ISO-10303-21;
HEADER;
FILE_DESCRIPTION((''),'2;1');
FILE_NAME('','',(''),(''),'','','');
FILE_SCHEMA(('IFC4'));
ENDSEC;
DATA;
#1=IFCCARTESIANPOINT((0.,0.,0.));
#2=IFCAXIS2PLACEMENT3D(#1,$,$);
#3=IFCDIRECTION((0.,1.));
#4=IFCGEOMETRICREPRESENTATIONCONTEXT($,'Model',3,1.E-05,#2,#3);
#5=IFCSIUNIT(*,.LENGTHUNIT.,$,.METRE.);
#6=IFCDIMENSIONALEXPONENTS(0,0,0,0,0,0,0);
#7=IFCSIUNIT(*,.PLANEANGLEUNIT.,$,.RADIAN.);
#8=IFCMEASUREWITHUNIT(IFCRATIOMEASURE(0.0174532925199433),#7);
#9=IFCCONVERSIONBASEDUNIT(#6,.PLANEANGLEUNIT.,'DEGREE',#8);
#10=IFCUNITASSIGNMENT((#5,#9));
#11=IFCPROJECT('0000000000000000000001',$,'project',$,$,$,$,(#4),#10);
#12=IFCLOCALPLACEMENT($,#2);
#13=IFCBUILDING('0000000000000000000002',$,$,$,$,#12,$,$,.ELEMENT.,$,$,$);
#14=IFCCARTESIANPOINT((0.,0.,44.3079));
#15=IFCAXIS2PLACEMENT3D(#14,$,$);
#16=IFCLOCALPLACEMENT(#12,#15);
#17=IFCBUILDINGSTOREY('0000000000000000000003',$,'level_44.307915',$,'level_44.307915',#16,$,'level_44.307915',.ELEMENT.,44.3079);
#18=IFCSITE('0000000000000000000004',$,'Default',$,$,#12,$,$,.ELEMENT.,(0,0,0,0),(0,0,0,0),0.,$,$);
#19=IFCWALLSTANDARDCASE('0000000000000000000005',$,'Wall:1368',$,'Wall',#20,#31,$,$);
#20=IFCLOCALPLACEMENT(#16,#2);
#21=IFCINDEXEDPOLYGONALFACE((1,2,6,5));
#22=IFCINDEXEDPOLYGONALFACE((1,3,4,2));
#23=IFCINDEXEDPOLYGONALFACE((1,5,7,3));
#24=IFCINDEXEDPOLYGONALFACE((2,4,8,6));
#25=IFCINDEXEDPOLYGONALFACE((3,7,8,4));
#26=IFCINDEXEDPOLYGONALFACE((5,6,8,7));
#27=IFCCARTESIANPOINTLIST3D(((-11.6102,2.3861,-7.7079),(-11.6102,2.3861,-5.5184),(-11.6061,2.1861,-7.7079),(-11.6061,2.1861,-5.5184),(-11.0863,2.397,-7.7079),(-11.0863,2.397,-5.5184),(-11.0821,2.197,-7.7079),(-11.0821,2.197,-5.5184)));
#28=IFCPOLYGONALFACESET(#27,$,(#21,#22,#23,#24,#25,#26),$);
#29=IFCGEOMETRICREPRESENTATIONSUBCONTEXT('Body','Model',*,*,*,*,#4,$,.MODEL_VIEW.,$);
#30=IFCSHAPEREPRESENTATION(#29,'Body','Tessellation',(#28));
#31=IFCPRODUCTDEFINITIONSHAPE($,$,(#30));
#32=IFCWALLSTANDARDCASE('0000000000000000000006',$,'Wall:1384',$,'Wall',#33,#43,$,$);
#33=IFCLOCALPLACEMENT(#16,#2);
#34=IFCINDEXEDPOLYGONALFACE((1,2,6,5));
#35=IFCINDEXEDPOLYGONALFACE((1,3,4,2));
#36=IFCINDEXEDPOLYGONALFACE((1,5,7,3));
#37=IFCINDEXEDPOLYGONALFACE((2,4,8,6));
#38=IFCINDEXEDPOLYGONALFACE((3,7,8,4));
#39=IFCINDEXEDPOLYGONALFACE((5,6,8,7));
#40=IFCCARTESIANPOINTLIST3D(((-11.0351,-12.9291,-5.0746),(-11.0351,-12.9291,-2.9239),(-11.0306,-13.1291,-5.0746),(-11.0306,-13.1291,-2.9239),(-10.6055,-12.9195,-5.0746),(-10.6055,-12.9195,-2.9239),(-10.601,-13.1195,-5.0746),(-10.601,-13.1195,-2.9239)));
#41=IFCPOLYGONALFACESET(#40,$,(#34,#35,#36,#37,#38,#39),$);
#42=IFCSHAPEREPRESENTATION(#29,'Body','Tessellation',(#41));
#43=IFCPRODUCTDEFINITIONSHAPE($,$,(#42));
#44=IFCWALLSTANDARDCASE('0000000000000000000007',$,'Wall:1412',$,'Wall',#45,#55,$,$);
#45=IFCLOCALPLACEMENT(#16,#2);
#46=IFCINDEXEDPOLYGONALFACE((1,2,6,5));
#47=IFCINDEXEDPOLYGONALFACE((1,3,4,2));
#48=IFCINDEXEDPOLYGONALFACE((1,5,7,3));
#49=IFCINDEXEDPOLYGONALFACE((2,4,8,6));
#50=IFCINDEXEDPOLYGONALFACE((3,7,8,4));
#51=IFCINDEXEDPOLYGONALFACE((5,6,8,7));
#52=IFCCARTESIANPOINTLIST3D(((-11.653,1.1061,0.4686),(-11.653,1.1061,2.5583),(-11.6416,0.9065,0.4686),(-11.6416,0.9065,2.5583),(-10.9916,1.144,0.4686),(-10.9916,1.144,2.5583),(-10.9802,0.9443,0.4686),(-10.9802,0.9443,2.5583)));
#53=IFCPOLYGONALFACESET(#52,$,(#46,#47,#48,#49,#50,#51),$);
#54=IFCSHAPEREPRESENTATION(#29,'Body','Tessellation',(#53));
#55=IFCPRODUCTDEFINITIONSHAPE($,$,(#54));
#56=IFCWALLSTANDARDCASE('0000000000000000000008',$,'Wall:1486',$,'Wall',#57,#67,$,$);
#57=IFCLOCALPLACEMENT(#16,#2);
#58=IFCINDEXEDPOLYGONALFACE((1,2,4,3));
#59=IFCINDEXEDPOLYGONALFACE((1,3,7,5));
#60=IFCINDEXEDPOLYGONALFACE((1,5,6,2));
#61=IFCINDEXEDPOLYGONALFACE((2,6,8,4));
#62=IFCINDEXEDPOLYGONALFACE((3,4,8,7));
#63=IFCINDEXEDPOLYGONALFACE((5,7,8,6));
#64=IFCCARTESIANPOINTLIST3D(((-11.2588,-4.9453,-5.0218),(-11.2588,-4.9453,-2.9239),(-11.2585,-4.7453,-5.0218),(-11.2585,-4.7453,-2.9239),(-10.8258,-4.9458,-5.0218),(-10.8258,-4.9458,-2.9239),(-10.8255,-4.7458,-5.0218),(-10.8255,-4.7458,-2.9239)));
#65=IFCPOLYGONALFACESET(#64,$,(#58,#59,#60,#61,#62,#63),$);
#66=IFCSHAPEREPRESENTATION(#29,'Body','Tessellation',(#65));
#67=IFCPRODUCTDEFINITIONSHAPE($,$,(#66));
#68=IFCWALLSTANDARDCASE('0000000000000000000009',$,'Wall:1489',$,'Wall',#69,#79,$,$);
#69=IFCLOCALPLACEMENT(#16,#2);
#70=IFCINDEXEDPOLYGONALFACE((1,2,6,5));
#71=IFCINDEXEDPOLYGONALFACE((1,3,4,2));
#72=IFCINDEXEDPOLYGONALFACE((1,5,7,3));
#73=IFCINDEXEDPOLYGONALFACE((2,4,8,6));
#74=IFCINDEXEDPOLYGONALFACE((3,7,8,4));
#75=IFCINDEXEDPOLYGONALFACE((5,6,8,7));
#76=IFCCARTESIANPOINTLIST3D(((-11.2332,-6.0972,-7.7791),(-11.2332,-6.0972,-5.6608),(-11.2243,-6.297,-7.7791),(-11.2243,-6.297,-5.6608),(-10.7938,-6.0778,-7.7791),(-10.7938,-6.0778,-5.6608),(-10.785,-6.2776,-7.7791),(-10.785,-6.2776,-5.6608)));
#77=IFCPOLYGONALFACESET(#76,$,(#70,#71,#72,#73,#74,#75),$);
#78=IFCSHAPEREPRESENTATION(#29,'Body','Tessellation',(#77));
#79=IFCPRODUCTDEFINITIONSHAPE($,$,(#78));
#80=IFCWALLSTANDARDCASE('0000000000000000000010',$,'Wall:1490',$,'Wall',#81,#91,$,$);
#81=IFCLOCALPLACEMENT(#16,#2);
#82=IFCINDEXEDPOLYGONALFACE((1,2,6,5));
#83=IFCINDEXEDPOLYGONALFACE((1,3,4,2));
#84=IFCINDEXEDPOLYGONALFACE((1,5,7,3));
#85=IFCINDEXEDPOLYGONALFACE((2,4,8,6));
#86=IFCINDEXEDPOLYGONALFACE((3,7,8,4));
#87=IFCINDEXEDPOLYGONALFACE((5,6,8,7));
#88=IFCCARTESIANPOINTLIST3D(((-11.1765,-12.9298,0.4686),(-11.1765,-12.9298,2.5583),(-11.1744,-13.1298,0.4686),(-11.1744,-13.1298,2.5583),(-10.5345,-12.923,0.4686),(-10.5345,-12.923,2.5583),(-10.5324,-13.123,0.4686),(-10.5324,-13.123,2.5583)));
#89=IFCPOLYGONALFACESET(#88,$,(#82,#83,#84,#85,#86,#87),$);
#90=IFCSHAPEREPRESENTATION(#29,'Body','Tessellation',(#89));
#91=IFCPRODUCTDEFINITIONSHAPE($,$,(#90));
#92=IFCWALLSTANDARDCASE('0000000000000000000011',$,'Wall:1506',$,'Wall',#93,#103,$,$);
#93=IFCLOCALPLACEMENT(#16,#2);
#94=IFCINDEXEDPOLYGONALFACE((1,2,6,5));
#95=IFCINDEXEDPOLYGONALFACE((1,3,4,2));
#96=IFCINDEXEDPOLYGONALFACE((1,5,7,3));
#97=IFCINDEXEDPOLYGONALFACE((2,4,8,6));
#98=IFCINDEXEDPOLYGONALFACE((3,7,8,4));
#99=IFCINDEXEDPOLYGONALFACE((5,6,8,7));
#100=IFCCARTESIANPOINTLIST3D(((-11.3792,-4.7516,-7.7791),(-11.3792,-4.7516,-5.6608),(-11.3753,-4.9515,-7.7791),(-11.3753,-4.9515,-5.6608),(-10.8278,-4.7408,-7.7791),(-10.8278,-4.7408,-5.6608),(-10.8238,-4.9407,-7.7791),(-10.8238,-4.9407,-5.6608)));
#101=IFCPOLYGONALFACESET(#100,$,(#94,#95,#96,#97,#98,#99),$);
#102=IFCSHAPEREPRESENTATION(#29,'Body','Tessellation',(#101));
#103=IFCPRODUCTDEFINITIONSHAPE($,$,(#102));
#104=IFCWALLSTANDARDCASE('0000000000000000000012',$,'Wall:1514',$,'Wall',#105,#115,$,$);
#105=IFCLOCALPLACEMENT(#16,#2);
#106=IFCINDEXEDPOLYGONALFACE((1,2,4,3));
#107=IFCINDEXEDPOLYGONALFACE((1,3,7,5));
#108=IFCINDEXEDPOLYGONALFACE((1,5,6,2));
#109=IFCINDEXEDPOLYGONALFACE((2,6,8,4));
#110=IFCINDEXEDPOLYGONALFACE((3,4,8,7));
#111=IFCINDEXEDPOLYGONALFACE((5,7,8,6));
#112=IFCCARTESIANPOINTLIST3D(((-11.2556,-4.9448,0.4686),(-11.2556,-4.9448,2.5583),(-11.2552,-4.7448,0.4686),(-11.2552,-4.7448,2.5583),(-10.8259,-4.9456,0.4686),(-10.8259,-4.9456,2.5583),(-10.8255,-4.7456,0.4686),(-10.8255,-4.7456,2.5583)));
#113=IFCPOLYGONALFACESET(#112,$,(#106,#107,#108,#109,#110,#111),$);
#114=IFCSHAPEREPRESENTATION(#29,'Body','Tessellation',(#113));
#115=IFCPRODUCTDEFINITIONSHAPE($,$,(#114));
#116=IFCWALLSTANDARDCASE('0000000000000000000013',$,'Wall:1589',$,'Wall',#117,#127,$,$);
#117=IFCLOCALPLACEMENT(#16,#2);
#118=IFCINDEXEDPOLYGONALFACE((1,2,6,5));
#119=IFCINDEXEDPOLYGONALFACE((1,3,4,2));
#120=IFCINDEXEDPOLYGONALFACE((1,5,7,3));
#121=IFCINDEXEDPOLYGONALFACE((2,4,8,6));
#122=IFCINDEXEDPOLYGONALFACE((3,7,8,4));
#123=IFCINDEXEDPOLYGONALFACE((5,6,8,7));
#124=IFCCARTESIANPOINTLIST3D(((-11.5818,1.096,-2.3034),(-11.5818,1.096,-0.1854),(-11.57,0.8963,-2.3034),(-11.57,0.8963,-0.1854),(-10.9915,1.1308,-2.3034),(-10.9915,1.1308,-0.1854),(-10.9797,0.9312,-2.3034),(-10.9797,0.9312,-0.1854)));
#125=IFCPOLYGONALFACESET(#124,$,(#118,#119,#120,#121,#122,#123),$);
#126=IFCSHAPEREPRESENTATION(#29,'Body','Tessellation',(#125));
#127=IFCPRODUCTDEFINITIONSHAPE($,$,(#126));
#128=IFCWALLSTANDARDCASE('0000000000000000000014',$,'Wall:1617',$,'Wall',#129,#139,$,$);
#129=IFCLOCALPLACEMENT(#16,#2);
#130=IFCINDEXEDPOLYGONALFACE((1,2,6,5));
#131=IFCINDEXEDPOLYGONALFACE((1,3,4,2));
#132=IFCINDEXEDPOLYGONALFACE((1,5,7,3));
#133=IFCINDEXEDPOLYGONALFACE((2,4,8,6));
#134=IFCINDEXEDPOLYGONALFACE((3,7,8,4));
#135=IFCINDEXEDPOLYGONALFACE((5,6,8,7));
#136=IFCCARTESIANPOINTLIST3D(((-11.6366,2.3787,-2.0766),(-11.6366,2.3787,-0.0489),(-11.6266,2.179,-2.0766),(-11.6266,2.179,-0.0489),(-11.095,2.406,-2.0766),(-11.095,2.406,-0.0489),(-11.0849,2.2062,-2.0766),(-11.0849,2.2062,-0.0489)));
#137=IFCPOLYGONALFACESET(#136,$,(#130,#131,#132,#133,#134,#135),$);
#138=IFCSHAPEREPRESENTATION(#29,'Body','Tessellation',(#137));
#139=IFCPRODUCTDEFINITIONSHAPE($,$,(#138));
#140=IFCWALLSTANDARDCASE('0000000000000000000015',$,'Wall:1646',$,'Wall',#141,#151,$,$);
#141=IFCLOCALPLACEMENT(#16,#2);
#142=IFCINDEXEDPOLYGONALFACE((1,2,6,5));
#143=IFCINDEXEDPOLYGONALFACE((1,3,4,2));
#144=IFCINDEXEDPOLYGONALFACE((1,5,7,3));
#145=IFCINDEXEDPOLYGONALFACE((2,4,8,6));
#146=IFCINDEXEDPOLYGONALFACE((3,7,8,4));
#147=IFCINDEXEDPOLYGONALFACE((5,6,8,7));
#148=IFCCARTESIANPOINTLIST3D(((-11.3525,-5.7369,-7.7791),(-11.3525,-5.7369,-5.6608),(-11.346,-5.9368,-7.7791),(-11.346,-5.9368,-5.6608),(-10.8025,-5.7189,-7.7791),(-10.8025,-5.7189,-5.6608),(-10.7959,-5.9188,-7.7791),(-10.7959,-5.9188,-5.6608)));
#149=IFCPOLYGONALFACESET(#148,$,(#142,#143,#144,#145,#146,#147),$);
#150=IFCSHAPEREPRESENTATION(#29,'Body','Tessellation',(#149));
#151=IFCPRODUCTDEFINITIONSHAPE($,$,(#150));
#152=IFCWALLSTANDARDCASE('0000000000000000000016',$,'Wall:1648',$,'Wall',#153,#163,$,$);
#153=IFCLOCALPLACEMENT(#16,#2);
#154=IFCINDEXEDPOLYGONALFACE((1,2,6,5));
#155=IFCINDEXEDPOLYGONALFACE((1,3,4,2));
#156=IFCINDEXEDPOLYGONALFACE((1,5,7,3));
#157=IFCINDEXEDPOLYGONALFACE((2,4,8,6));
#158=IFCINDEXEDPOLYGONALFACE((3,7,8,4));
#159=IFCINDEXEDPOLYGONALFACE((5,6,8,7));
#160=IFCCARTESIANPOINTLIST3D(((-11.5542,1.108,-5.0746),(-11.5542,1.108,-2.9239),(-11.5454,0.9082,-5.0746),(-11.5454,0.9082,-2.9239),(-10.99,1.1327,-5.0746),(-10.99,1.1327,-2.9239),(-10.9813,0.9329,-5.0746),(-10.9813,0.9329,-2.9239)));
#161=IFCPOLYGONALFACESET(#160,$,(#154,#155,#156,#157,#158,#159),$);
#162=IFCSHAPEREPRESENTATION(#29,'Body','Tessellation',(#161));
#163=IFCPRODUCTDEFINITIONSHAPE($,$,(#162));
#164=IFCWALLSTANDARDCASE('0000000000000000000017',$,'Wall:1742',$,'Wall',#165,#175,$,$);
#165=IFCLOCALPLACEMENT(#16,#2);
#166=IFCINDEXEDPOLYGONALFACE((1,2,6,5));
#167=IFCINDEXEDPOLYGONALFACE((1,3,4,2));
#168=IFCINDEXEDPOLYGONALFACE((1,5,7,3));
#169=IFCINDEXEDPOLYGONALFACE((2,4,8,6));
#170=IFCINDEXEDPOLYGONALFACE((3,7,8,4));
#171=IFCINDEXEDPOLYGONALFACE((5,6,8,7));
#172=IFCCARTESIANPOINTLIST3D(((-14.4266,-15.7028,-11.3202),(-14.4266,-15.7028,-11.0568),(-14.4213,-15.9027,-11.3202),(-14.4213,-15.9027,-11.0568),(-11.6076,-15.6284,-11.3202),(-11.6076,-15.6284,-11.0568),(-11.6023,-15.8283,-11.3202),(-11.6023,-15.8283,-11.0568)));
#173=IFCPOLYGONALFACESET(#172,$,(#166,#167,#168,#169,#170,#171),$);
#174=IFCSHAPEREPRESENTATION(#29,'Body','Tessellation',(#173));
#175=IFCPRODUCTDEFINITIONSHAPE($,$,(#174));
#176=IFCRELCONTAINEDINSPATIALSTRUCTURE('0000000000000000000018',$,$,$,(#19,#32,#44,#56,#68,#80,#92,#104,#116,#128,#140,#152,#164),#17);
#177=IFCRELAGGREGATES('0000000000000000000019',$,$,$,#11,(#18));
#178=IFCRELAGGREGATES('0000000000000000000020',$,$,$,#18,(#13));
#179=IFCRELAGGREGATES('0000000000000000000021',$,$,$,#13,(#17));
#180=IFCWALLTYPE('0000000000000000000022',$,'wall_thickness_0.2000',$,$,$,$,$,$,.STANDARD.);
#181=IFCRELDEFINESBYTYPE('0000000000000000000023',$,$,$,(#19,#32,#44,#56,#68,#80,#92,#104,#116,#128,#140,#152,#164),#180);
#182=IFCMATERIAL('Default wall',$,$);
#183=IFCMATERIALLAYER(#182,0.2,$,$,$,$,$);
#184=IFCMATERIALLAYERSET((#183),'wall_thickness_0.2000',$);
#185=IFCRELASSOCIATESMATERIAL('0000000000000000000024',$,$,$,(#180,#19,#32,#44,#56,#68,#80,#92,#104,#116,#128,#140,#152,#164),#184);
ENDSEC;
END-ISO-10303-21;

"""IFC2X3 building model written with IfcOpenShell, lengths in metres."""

from ifc_helpers import new_model, entity, si_unit, converted_unit, direction, frame, origin, place, context, subcontext, project, spatial, polyline, outline, extrude, material, layer, layer_set, layer_usage, type_object, element, save


model = new_model("IFC2X3")

# Units and contexts
model_context = context("Model", 3, precision=1e-05, world=origin(), true_north=direction((0.0, 1.0)))
body_context = subcontext(model_context, "Body", "Model", "MODEL_VIEW")
ifc_project = project(units=[si_unit("LENGTHUNIT", "METRE"), converted_unit("PLANEANGLEUNIT", "DEGREE", entity("IfcRatioMeasure", 0.0174532925199433), si_unit("PLANEANGLEUNIT", "RADIAN"), dimensions=[0, 0, 0, 0, 0, 0, 0])], contexts=[model_context])

# Site, building, storey
placement_1 = place(None, origin())
site = spatial("IfcSite", under=ifc_project, at=placement_1, Name="Default", CompositionType="ELEMENT", RefLatitude=(0, 0, 0, 0), RefLongitude=(0, 0, 0, 0), RefElevation=0.0)
building = spatial("IfcBuilding", under=site, at=placement_1, CompositionType="ELEMENT")
storey_placement = place(placement_1, frame((0.0, 0.0, 44.3079)))
storey = spatial("IfcBuildingStorey", under=building, at=storey_placement, Name="level_44.307915", ObjectType="level_44.307915", LongName="level_44.307915", CompositionType="ELEMENT", Elevation=44.3079)

# Walls
ifc_material_1 = material(Name="Default wall")
ifc_layer = layer(ifc_material_1, 0.2)
ifc_layer_set = layer_set([ifc_layer], Name="wall_thickness_0.2000")
ifc_layer_usage = layer_usage(ifc_layer_set, "AXIS2", "POSITIVE", -0.1)
wall_type = type_object("IfcWallType", Name="wall_thickness_0.2000", PredefinedType="STANDARD", material=ifc_layer_set)
placement_2 = place(placement_1, frame((0.0, 0.0, 36.6)))
wall_1_placement = place(placement_2, frame((-11.0842, 2.297, 0.0), z_axis=(0.0, 0.0, 1.0), x_axis=(-0.999783, -0.020848, 0.0)))
element("IfcWallStandardCase", 1, at=wall_1_placement, inside=storey, type_object=wall_type, material=ifc_layer_usage, Name="Wall:1368", ObjectType="Wall", context=body_context, shape_type="SweptSolid", body=[
    extrude(outline(polyline([(0.5241, -0.1), (0.5241, 0.1), (0.0, 0.1), (0.0, -0.1), (0.5241, -0.1)])), origin(), (0.0, 0.0, 1.0), 2.1895),
])
placement_3 = place(placement_1, frame((0.0, 0.0, 39.2333)))
wall_2_placement = place(placement_3, frame((-10.6033, -13.0195, 0.0), z_axis=(0.0, 0.0, 1.0), x_axis=(-0.99975, -0.022373, 0.0)))
element("IfcWallStandardCase", 2, at=wall_2_placement, inside=storey, type_object=wall_type, material=ifc_layer_usage, Name="Wall:1384", ObjectType="Wall", context=body_context, shape_type="SweptSolid", body=[
    extrude(outline(polyline([(0.4297, -0.1), (0.4297, 0.1), (0.0, 0.1), (0.0, -0.1), (0.4297, -0.1)])), origin(), (0.0, 0.0, 1.0), 2.1507),
])
placement_4 = place(placement_1, frame((0.0, 0.0, 44.7765)))
wall_3_placement = place(placement_4, frame((-10.9859, 1.0441, 0.0), z_axis=(0.0, 0.0, 1.0), x_axis=(-0.99837, -0.05708, 0.0)))
element("IfcWallStandardCase", 3, at=wall_3_placement, inside=storey, type_object=wall_type, material=ifc_layer_usage, Name="Wall:1412", ObjectType="Wall", context=body_context, shape_type="SweptSolid", body=[
    extrude(outline(polyline([(0.6624, -0.1), (0.6624, 0.1), (0.0, 0.1), (0.0, -0.1), (0.6624, -0.1)])), origin(), (0.0, 0.0, 1.0), 2.0897),
])
placement_5 = place(placement_1, frame((0.0, 0.0, 39.2861)))
wall_4_placement = place(placement_5, frame((-10.8257, -4.8458, 0.0), z_axis=(0.0, 0.0, 1.0), x_axis=(-0.999999, 0.001249, 0.0)))
element("IfcWallStandardCase", 4, at=wall_4_placement, inside=storey, type_object=wall_type, material=ifc_layer_usage, Name="Wall:1486", ObjectType="Wall", context=body_context, shape_type="SweptSolid", body=[
    extrude(outline(polyline([(0.433, -0.1), (0.433, 0.1), (0.0, 0.1), (0.0, -0.1), (0.433, -0.1)])), origin(), (0.0, 0.0, 1.0), 2.0979),
])
placement_6 = place(placement_1, frame((0.0, 0.0, 36.5288)))
wall_5_placement = place(placement_6, frame((-10.7894, -6.1777, 0.0), z_axis=(0.0, 0.0, 1.0), x_axis=(-0.999024, -0.044163, 0.0)))
element("IfcWallStandardCase", 5, at=wall_5_placement, inside=storey, type_object=wall_type, material=ifc_layer_usage, Name="Wall:1489", ObjectType="Wall", context=body_context, shape_type="SweptSolid", body=[
    extrude(outline(polyline([(0.4398, -0.1), (0.4398, 0.1), (0.0, 0.1), (0.0, -0.1), (0.4398, -0.1)])), origin(), (0.0, 0.0, 1.0), 2.1183),
])
placement_7 = place(placement_1, frame((0.0, 0.0, 44.7765)))
wall_6_placement = place(placement_7, frame((-10.5334, -13.023, 0.0), z_axis=(0.0, 0.0, 1.0), x_axis=(-0.999945, -0.010496, 0.0)))
element("IfcWallStandardCase", 6, at=wall_6_placement, inside=storey, type_object=wall_type, material=ifc_layer_usage, Name="Wall:1490", ObjectType="Wall", context=body_context, shape_type="SweptSolid", body=[
    extrude(outline(polyline([(0.6421, -0.1), (0.6421, 0.1), (0.0, 0.1), (0.0, -0.1), (0.6421, -0.1)])), origin(), (0.0, 0.0, 1.0), 2.0897),
])
placement_8 = place(placement_1, frame((0.0, 0.0, 36.5288)))
wall_7_placement = place(placement_8, frame((-10.8258, -4.8407, 0.0), z_axis=(0.0, 0.0, 1.0), x_axis=(-0.999808, -0.019607, 0.0)))
element("IfcWallStandardCase", 7, at=wall_7_placement, inside=storey, type_object=wall_type, material=ifc_layer_usage, Name="Wall:1506", ObjectType="Wall", context=body_context, shape_type="SweptSolid", body=[
    extrude(outline(polyline([(0.5516, -0.1), (0.5516, 0.1), (0.0, 0.1), (0.0, -0.1), (0.5516, -0.1)])), origin(), (0.0, 0.0, 1.0), 2.1183),
])
placement_9 = place(placement_1, frame((0.0, 0.0, 44.7765)))
wall_8_placement = place(placement_9, frame((-10.8257, -4.8456, 0.0), z_axis=(0.0, 0.0, 1.0), x_axis=(-0.999998, 0.001954, 0.0)))
element("IfcWallStandardCase", 8, at=wall_8_placement, inside=storey, type_object=wall_type, material=ifc_layer_usage, Name="Wall:1514", ObjectType="Wall", context=body_context, shape_type="SweptSolid", body=[
    extrude(outline(polyline([(0.4297, -0.1), (0.4297, 0.1), (0.0, 0.1), (0.0, -0.1), (0.4297, -0.1)])), origin(), (0.0, 0.0, 1.0), 2.0897),
])
placement_10 = place(placement_1, frame((0.0, 0.0, 42.0045)))
wall_9_placement = place(placement_10, frame((-10.9856, 1.031, 0.0), z_axis=(0.0, 0.0, 1.0), x_axis=(-0.998263, -0.05892, 0.0)))
element("IfcWallStandardCase", 9, at=wall_9_placement, inside=storey, type_object=wall_type, material=ifc_layer_usage, Name="Wall:1589", ObjectType="Wall", context=body_context, shape_type="SweptSolid", body=[
    extrude(outline(polyline([(0.5913, -0.1), (0.5913, 0.1), (0.0, 0.1), (0.0, -0.1), (0.5913, -0.1)])), origin(), (0.0, 0.0, 1.0), 2.118),
])
placement_11 = place(placement_1, frame((0.0, 0.0, 42.2313)))
wall_10_placement = place(placement_11, frame((-11.0899, 2.3061, 0.0), z_axis=(0.0, 0.0, 1.0), x_axis=(-0.998738, -0.050226, 0.0)))
element("IfcWallStandardCase", 10, at=wall_10_placement, inside=storey, type_object=wall_type, material=ifc_layer_usage, Name="Wall:1617", ObjectType="Wall", context=body_context, shape_type="SweptSolid", body=[
    extrude(outline(polyline([(0.5423, -0.1), (0.5423, 0.1), (0.0, 0.1), (0.0, -0.1), (0.5423, -0.1)])), origin(), (0.0, 0.0, 1.0), 2.0278),
])
placement_12 = place(placement_1, frame((0.0, 0.0, 36.5288)))
wall_11_placement = place(placement_12, frame((-10.7992, -5.8188, 0.0), z_axis=(0.0, 0.0, 1.0), x_axis=(-0.999462, -0.032802, 0.0)))
element("IfcWallStandardCase", 11, at=wall_11_placement, inside=storey, type_object=wall_type, material=ifc_layer_usage, Name="Wall:1646", ObjectType="Wall", context=body_context, shape_type="SweptSolid", body=[
    extrude(outline(polyline([(0.5504, -0.1), (0.5504, 0.1), (0.0, 0.1), (0.0, -0.1), (0.5504, -0.1)])), origin(), (0.0, 0.0, 1.0), 2.1183),
])
placement_13 = place(placement_1, frame((0.0, 0.0, 39.2333)))
wall_12_placement = place(placement_13, frame((-10.9856, 1.0328, 0.0), z_axis=(0.0, 0.0, 1.0), x_axis=(-0.999039, -0.043838, 0.0)))
element("IfcWallStandardCase", 12, at=wall_12_placement, inside=storey, type_object=wall_type, material=ifc_layer_usage, Name="Wall:1648", ObjectType="Wall", context=body_context, shape_type="SweptSolid", body=[
    extrude(outline(polyline([(0.5647, -0.1), (0.5647, 0.1), (0.0, 0.1), (0.0, -0.1), (0.5647, -0.1)])), origin(), (0.0, 0.0, 1.0), 2.1507),
])
placement_14 = place(placement_1, frame((0.0, 0.0, 32.9877)))
wall_13_placement = place(placement_14, frame((-14.424, -15.8027, 0.0), z_axis=(0.0, 0.0, 1.0), x_axis=(0.999652, 0.026361, 0.0)))
element("IfcWallStandardCase", 13, at=wall_13_placement, inside=storey, type_object=wall_type, material=ifc_layer_usage, Name="Wall:1742", ObjectType="Wall", context=body_context, shape_type="SweptSolid", body=[
    extrude(outline(polyline([(2.82, -0.1), (2.82, 0.1), (0.0, 0.1), (0.0, -0.1), (2.82, -0.1)])), origin(), (0.0, 0.0, 1.0), 0.2634),
])

save(model, "model.ifc")
